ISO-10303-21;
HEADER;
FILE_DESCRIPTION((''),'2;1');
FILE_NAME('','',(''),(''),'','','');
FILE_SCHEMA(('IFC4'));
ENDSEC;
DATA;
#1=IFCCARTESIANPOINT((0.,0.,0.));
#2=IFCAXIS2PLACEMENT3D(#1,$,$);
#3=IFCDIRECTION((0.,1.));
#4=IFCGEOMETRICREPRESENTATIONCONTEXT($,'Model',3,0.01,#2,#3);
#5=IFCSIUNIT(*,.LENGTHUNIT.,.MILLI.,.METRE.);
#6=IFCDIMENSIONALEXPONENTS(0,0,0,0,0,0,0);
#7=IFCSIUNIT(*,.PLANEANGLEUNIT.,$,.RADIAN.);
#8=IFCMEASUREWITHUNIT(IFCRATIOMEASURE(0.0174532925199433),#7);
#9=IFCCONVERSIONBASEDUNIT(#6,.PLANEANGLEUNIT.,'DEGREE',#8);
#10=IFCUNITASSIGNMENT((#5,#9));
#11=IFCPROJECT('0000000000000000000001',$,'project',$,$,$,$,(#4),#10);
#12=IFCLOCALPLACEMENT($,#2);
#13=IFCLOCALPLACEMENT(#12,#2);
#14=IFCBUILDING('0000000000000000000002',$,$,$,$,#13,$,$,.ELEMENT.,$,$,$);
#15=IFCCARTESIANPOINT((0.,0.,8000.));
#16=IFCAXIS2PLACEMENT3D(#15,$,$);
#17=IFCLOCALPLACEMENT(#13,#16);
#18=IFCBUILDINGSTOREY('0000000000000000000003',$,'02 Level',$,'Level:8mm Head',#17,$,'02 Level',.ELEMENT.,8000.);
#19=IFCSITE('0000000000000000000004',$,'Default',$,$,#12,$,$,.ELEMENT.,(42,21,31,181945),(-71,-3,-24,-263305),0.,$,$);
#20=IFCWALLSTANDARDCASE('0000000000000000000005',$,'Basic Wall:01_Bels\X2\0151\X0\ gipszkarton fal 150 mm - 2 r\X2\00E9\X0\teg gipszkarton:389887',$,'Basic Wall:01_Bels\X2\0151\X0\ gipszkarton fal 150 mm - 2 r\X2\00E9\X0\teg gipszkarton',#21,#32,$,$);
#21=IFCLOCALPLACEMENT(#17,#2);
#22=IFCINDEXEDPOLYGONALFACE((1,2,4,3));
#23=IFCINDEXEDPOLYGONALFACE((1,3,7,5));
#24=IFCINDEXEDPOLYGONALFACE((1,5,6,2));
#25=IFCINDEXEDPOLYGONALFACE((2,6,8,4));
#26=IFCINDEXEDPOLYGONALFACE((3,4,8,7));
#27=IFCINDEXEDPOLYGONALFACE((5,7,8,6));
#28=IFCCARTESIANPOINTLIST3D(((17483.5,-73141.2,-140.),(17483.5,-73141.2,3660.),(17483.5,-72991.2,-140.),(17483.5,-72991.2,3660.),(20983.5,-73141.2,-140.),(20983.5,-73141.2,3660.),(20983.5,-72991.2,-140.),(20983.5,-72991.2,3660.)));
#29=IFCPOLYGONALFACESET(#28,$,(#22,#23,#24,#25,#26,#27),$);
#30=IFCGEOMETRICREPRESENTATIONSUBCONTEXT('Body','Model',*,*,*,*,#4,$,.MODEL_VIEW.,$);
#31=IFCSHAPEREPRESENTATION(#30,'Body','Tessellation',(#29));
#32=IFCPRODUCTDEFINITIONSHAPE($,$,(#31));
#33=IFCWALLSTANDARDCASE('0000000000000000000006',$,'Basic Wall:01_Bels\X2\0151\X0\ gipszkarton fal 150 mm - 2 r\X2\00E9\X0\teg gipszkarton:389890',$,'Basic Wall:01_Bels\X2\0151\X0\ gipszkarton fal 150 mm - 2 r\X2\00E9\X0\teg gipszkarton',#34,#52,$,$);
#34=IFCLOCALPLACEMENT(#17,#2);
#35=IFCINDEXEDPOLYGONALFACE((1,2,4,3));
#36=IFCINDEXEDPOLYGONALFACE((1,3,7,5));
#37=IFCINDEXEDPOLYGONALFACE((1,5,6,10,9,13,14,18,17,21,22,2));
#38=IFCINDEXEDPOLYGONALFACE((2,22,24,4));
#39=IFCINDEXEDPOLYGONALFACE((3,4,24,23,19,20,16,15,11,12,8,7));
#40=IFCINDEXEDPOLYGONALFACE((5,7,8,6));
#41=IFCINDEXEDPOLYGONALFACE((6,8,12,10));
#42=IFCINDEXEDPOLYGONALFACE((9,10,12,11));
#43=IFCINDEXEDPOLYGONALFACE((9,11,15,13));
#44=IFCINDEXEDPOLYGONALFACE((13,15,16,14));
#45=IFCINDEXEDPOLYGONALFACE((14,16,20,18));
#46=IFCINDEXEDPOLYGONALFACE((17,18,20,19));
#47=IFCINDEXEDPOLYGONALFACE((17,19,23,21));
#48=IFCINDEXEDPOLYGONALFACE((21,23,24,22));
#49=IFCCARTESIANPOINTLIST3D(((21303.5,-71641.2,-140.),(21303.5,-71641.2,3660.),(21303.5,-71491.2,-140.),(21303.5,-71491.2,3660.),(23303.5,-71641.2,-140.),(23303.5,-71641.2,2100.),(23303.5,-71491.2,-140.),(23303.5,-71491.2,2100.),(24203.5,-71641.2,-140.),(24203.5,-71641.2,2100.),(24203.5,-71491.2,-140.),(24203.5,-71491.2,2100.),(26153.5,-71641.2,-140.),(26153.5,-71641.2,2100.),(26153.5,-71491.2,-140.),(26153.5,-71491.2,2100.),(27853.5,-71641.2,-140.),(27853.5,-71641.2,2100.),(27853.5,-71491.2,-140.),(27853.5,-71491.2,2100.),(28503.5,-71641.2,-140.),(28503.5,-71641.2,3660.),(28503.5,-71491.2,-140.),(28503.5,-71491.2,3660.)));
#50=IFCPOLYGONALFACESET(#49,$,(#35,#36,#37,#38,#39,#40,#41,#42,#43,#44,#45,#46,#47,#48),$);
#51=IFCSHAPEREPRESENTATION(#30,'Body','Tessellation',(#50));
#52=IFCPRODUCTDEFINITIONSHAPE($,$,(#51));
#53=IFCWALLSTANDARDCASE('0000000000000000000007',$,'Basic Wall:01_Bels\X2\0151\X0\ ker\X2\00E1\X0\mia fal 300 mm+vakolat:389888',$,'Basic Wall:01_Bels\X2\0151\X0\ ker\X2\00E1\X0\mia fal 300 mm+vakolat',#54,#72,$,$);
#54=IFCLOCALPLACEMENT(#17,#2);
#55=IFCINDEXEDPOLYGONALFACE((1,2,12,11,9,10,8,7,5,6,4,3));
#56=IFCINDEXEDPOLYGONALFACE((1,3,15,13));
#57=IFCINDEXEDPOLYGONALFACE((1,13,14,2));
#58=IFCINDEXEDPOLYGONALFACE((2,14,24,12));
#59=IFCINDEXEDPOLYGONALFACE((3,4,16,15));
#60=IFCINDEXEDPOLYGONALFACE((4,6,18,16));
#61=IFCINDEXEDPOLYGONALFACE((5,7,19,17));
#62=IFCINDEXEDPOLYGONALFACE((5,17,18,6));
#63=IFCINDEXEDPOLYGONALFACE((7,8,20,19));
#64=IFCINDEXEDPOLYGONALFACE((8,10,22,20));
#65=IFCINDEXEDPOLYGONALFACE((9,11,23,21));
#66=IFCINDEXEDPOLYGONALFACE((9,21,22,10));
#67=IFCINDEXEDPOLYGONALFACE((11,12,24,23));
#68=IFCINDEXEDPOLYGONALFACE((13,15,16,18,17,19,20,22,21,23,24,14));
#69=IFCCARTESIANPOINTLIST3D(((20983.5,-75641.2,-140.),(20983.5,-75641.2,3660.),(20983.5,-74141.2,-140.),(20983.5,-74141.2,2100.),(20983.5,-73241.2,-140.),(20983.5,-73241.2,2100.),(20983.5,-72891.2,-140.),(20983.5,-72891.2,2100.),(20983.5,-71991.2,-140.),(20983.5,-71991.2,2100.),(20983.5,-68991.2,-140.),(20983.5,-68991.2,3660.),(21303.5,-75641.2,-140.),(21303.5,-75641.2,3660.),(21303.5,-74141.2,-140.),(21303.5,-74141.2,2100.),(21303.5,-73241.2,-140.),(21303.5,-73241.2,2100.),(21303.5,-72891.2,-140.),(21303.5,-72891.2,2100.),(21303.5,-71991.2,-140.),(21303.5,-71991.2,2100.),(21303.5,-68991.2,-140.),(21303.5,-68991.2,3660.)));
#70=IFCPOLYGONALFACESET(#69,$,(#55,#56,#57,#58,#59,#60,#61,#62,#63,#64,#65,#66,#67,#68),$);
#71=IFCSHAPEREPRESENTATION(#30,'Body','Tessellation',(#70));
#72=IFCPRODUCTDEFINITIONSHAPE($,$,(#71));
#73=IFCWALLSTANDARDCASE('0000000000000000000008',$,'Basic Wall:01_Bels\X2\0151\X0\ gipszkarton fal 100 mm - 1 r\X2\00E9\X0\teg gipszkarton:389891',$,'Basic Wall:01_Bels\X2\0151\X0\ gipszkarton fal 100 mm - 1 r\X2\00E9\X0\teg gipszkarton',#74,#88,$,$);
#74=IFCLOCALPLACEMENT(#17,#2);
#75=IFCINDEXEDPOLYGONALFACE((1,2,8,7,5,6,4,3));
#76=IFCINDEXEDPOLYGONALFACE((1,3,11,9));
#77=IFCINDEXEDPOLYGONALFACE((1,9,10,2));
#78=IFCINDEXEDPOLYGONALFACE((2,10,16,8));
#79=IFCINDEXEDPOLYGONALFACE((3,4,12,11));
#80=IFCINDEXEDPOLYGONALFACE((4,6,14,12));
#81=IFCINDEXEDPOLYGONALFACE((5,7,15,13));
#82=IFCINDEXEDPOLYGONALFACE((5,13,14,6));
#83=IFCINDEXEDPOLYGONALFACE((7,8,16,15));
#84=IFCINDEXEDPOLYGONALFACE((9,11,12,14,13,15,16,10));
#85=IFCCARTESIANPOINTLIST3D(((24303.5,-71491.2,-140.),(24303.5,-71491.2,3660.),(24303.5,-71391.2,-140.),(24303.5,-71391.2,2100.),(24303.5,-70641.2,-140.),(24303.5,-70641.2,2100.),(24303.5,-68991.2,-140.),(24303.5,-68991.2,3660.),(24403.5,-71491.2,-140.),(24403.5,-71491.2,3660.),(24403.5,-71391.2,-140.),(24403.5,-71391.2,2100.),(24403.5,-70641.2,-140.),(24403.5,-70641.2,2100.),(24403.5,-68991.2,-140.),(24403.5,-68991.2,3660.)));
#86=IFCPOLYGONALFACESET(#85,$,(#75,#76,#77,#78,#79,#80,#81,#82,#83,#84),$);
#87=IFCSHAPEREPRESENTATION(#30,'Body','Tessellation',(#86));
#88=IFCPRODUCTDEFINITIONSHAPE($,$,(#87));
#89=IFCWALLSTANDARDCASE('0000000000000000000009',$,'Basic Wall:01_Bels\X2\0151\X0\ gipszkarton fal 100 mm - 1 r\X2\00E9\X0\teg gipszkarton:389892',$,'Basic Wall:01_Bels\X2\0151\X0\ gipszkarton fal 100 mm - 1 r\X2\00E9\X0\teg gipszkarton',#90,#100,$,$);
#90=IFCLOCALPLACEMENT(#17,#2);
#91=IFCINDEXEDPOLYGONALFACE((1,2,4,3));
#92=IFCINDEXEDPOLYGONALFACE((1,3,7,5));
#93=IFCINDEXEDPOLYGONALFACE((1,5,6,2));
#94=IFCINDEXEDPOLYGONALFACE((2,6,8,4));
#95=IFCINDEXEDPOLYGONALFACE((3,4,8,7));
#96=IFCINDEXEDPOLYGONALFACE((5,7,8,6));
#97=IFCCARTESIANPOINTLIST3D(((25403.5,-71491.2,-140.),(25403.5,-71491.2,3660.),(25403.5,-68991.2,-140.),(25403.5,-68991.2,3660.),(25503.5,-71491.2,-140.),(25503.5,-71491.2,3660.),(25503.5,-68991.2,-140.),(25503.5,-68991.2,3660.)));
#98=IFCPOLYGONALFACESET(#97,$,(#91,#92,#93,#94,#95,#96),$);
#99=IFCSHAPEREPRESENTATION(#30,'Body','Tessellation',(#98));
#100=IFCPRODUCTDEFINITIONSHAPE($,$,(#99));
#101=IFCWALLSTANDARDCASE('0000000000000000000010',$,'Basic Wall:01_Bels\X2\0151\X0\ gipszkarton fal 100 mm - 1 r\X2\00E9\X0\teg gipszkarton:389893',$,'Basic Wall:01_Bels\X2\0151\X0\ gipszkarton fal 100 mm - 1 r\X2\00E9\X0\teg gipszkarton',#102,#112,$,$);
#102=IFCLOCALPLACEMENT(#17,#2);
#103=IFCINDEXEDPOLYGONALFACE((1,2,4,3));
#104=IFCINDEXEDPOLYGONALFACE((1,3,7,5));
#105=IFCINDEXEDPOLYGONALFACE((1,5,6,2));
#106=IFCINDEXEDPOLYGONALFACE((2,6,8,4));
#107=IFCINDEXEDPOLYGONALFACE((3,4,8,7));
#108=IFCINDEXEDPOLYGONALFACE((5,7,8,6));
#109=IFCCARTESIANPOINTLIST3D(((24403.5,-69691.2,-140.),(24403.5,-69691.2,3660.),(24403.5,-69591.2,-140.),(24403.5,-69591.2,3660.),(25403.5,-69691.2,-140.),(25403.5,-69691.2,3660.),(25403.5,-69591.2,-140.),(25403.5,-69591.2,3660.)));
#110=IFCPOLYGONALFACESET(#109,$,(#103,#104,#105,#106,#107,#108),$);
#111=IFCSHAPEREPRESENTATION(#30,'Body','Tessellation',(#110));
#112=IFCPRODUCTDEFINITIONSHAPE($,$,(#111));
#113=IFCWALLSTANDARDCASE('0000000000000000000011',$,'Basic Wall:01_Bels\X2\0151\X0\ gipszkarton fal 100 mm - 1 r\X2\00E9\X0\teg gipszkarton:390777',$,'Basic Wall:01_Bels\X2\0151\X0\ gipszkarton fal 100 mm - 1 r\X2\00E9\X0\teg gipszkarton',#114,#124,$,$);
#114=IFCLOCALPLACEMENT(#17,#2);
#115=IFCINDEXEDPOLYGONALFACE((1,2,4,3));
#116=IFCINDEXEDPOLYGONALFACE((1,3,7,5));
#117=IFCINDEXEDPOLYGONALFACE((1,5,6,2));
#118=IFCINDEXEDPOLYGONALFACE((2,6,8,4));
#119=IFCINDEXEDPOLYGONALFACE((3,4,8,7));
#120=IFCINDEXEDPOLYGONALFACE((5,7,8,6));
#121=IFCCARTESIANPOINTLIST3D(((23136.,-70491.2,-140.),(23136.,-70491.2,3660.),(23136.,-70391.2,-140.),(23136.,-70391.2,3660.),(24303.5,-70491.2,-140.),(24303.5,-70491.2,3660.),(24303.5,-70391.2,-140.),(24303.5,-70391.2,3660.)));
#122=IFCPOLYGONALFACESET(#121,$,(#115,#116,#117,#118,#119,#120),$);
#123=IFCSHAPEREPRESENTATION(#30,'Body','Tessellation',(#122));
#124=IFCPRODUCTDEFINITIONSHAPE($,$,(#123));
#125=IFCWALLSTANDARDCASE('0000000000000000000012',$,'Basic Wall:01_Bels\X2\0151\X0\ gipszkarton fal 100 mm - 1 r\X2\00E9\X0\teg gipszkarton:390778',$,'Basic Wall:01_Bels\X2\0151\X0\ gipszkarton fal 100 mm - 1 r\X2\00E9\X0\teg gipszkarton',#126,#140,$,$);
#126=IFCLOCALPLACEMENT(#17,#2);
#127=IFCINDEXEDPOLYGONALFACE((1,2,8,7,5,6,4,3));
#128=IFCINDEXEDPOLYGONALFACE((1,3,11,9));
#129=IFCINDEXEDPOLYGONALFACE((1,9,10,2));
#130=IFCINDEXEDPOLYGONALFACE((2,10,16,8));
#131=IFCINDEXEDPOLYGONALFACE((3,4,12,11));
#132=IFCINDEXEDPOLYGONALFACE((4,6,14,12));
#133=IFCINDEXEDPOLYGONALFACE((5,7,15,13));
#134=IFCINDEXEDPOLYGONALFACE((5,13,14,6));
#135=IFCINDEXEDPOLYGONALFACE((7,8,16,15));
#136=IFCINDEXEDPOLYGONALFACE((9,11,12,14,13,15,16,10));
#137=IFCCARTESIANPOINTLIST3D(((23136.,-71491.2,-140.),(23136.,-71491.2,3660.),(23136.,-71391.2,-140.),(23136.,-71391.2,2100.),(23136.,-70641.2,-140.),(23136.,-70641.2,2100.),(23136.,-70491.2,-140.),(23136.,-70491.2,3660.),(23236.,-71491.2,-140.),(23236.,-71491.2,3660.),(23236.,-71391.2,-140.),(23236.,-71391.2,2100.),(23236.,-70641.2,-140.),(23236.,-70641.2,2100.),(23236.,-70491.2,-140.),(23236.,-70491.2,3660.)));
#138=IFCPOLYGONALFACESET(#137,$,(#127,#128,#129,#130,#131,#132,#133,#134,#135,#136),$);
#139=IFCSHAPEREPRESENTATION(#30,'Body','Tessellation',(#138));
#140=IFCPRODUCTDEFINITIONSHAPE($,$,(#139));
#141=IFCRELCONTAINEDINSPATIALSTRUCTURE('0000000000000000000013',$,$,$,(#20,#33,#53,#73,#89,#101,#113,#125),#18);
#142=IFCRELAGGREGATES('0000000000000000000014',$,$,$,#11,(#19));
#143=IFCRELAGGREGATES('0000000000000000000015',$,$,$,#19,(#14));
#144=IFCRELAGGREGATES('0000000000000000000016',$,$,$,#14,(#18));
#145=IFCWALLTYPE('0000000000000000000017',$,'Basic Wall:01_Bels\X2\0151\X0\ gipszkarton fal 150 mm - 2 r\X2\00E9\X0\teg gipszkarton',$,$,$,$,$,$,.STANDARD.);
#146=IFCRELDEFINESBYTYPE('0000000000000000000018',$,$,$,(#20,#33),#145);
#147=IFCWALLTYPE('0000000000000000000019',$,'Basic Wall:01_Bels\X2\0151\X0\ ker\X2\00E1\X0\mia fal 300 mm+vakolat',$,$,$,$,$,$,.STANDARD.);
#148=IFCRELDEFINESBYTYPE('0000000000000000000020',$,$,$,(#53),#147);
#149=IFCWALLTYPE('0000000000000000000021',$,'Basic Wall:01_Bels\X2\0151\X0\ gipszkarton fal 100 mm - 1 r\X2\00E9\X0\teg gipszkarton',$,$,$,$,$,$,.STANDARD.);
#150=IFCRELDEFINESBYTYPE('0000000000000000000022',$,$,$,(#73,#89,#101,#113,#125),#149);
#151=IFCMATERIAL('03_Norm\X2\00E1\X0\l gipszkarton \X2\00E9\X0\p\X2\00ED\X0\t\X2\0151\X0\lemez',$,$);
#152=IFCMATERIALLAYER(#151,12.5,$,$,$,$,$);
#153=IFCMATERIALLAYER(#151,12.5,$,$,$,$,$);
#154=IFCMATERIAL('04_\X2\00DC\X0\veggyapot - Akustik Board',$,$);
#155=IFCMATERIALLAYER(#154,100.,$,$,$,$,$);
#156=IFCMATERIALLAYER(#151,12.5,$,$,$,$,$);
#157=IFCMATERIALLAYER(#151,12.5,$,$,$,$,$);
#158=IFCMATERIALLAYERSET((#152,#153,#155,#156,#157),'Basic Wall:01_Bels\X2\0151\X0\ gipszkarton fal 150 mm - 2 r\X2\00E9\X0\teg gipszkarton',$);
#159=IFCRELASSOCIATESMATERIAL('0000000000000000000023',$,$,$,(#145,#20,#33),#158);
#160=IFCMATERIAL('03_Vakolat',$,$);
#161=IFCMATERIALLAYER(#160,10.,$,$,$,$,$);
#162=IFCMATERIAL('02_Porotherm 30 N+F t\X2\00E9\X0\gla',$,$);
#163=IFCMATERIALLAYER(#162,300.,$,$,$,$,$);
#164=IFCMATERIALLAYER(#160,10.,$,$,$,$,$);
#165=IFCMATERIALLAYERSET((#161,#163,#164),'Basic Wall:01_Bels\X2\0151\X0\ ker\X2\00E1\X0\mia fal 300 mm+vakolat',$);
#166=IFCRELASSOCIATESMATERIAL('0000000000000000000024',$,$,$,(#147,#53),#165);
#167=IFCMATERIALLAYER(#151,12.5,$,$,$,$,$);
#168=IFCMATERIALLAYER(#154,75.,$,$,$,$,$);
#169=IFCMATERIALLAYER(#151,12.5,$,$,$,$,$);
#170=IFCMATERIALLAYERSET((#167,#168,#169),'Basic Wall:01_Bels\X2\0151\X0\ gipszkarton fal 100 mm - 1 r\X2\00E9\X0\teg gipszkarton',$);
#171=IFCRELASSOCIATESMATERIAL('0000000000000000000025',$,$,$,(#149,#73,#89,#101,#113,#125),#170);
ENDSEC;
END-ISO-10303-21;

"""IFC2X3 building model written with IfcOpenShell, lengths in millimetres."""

from ifc_helpers import new_model, entity, si_unit, converted_unit, direction, frame, frame_2d, origin, place, context, subcontext, project, spatial, rectangle, extrude, material, layer, layer_set, layer_usage, type_object, element, save


model = new_model("IFC2X3")

# Units and contexts
model_context = context("Model", 3, precision=0.01, world=origin(), true_north=direction((0.0, 1.0)))
body_context = subcontext(model_context, "Body", "Model", "MODEL_VIEW")
ifc_project = project(units=[si_unit("LENGTHUNIT", "METRE", prefix="MILLI"), converted_unit("PLANEANGLEUNIT", "DEGREE", entity("IfcRatioMeasure", 0.0174532925199433), si_unit("PLANEANGLEUNIT", "RADIAN"), dimensions=[0, 0, 0, 0, 0, 0, 0])], contexts=[model_context])

# Site, building, storey
site_placement = place(None, origin())
site = spatial("IfcSite", under=ifc_project, at=site_placement, Name="Default", CompositionType="ELEMENT", RefLatitude=(42, 21, 31, 181945), RefLongitude=(-71, -3, -24, -263305), RefElevation=0.0)
building_placement = place(site_placement, origin())
building = spatial("IfcBuilding", under=site, at=building_placement, CompositionType="ELEMENT")
storey_placement = place(building_placement, frame((0.0, 0.0, 8000.0)))
storey = spatial("IfcBuildingStorey", under=building, at=storey_placement, Name="02 Level", ObjectType="Level:8mm Head", LongName="02 Level", CompositionType="ELEMENT", Elevation=8000.0)

# Wall
ifc_material_1 = material(Name="03_Normál gipszkarton építőlemez")
ifc_layer_1 = layer(ifc_material_1, 12.5)
ifc_layer_2 = layer(ifc_material_1, 12.5)
ifc_material_2 = material(Name="04_Üveggyapot - Akustik Board")
ifc_layer_3 = layer(ifc_material_2, 100.0)
ifc_layer_4 = layer(ifc_material_1, 12.5)
ifc_layer_5 = layer(ifc_material_1, 12.5)
ifc_layer_set_1 = layer_set([ifc_layer_1, ifc_layer_2, ifc_layer_3, ifc_layer_4, ifc_layer_5], Name="Basic Wall:01_Belső gipszkarton fal 150 mm - 2 réteg gipszkarton")
ifc_layer_usage_1 = layer_usage(ifc_layer_set_1, "AXIS2", "NEGATIVE", 75.0)
wall_type_1 = type_object("IfcWallType", Name="Basic Wall:01_Belső gipszkarton fal 150 mm - 2 réteg gipszkarton", PredefinedType="STANDARD", material=ifc_layer_set_1)
wall_1_placement = place(storey_placement, frame((17483.5, -73066.2, -140.0)))
element("IfcWallStandardCase", 1, at=wall_1_placement, inside=storey, type_object=wall_type_1, material=ifc_layer_usage_1, Name="Basic Wall:01_Belső gipszkarton fal 150 mm - 2 réteg gipszkarton:389887", ObjectType="Basic Wall:01_Belső gipszkarton fal 150 mm - 2 réteg gipszkarton", context=body_context, shape_type="SweptSolid", body=[
    extrude(rectangle(XDim=3500.0, YDim=150.0, at=frame_2d((1750.0, 0.0), x_axis=(-1.0, 0.0))), origin(), (0.0, 0.0, 1.0), 3800.0),
])

# Walls, openings
ifc_layer_usage_2 = layer_usage(ifc_layer_set_1, "AXIS2", "NEGATIVE", 75.0)
wall_2_placement = place(storey_placement, frame((21303.5, -71566.2, -140.0)))
wall_2 = element("IfcWallStandardCase", 2, at=wall_2_placement, inside=storey, type_object=wall_type_1, material=ifc_layer_usage_2, Name="Basic Wall:01_Belső gipszkarton fal 150 mm - 2 réteg gipszkarton:389890", ObjectType="Basic Wall:01_Belső gipszkarton fal 150 mm - 2 réteg gipszkarton", context=body_context, shape_type="SweptSolid", body=[
    extrude(rectangle(XDim=7200.0, YDim=150.0, at=frame_2d((3600.0, 0.0), x_axis=(-1.0, 0.0))), origin(), (0.0, 0.0, 1.0), 3800.0),
])
opening_1_placement = place(wall_2_placement, frame((4850.0, -75.0, 0.0)))
element("IfcOpeningElement", 3, at=opening_1_placement, cuts=wall_2, ObjectType="Opening", context=body_context, shape_type="SweptSolid", body=[
    extrude(rectangle(XDim=2240.0, YDim=1700.0, at=frame_2d((0.0, 0.0), x_axis=(1.0, 0.0))), frame((850.0, 0.0, 1120.0), z_axis=(0.0, 1.0, 0.0), x_axis=(0.0, 0.0, -1.0)), (0.0, 0.0, 1.0), 150.0),
])
opening_2_placement = place(wall_2_placement, frame((2000.0, -1449.0, 0.0)))
element("IfcOpeningElement", 4, at=opening_2_placement, cuts=wall_2, ObjectType="Opening", context=body_context, shape_type="SweptSolid", body=[
    extrude(rectangle(XDim=2240.0, YDim=900.0, at=frame_2d((0.0, 0.0), x_axis=(0.0, 1.0))), frame((450.0, 0.0, 1120.0), z_axis=(0.0, 1.0, 0.0), x_axis=(-1.0, 0.0, 0.0)), (0.0, 0.0, 1.0), 3048.0),
])
ifc_material_3 = material(Name="03_Vakolat")
ifc_layer_6 = layer(ifc_material_3, 10.0)
ifc_material_4 = material(Name="02_Porotherm 30 N+F tégla")
ifc_layer_7 = layer(ifc_material_4, 300.0)
ifc_layer_8 = layer(ifc_material_3, 10.0)
ifc_layer_set_2 = layer_set([ifc_layer_6, ifc_layer_7, ifc_layer_8], Name="Basic Wall:01_Belső kerámia fal 300 mm+vakolat")
ifc_layer_usage_3 = layer_usage(ifc_layer_set_2, "AXIS2", "NEGATIVE", 160.0)
wall_type_2 = type_object("IfcWallType", Name="Basic Wall:01_Belső kerámia fal 300 mm+vakolat", PredefinedType="STANDARD", material=ifc_layer_set_2)
wall_3_placement = place(storey_placement, frame((21143.5, -68991.2, -140.0), z_axis=(0.0, 0.0, 1.0), x_axis=(0.0, -1.0, 0.0)))
wall_3 = element("IfcWallStandardCase", 5, at=wall_3_placement, inside=storey, type_object=wall_type_2, material=ifc_layer_usage_3, Name="Basic Wall:01_Belső kerámia fal 300 mm+vakolat:389888", ObjectType="Basic Wall:01_Belső kerámia fal 300 mm+vakolat", context=body_context, shape_type="SweptSolid", body=[
    extrude(rectangle(XDim=6650.0, YDim=320.0, at=frame_2d((3325.0, 0.0), x_axis=(-1.0, 0.0))), origin(), (0.0, 0.0, 1.0), 3800.0),
])
opening_3_placement = place(wall_3_placement, frame((3900.0, -1364.0, 0.0), z_axis=(0.0, 0.0, 1.0), x_axis=(0.0, 1.0, 0.0)))
element("IfcOpeningElement", 6, at=opening_3_placement, cuts=wall_3, ObjectType="Opening", context=body_context, shape_type="SweptSolid", body=[
    extrude(rectangle(XDim=2240.0, YDim=900.0, at=frame_2d((0.0, 0.0), x_axis=(1.0, 0.0))), frame((0.0, 450.0, 1120.0), z_axis=(1.0, 0.0, 0.0), x_axis=(0.0, 0.0, 1.0)), (0.0, 0.0, 1.0), 3048.0),
])
opening_4_placement = place(wall_3_placement, frame((5150.0, -1364.0, 0.0), z_axis=(0.0, 0.0, 1.0), x_axis=(0.0, 1.0, 0.0)))
element("IfcOpeningElement", 7, at=opening_4_placement, cuts=wall_3, ObjectType="Opening", context=body_context, shape_type="SweptSolid", body=[
    extrude(rectangle(XDim=2240.0, YDim=900.0, at=frame_2d((0.0, 0.0), x_axis=(0.0, 1.0))), frame((0.0, 450.0, 1120.0), z_axis=(1.0, 0.0, 0.0), x_axis=(0.0, 1.0, 0.0)), (0.0, 0.0, 1.0), 3048.0),
])

# Wall, opening
ifc_layer_9 = layer(ifc_material_1, 12.5)
ifc_layer_10 = layer(ifc_material_2, 75.0)
ifc_layer_11 = layer(ifc_material_1, 12.5)
ifc_layer_set_3 = layer_set([ifc_layer_9, ifc_layer_10, ifc_layer_11], Name="Basic Wall:01_Belső gipszkarton fal 100 mm - 1 réteg gipszkarton")
ifc_layer_usage_4 = layer_usage(ifc_layer_set_3, "AXIS2", "NEGATIVE", 50.0)
wall_type_3 = type_object("IfcWallType", Name="Basic Wall:01_Belső gipszkarton fal 100 mm - 1 réteg gipszkarton", PredefinedType="STANDARD", material=ifc_layer_set_3)
wall_4_placement = place(storey_placement, frame((24353.5, -71491.2, -140.0), z_axis=(0.0, 0.0, 1.0), x_axis=(0.0, 1.0, 0.0)))
wall_4 = element("IfcWallStandardCase", 8, at=wall_4_placement, inside=storey, type_object=wall_type_3, material=ifc_layer_usage_4, Name="Basic Wall:01_Belső gipszkarton fal 100 mm - 1 réteg gipszkarton:389891", ObjectType="Basic Wall:01_Belső gipszkarton fal 100 mm - 1 réteg gipszkarton", context=body_context, shape_type="SweptSolid", body=[
    extrude(rectangle(XDim=2500.0, YDim=100.0, at=frame_2d((1250.0, 0.0), x_axis=(-1.0, 0.0))), origin(), (0.0, 0.0, 1.0), 3800.0),
])
opening_5_placement = place(wall_4_placement, frame((100.0, 1574.0, 0.0), z_axis=(0.0, 0.0, 1.0), x_axis=(0.0, -1.0, 0.0)))
element("IfcOpeningElement", 9, at=opening_5_placement, cuts=wall_4, ObjectType="Opening", context=body_context, shape_type="SweptSolid", body=[
    extrude(rectangle(XDim=2240.0, YDim=750.0, at=frame_2d((0.0, 0.0), x_axis=(0.0, 1.0))), frame((3048.0, 375.0, 1120.0), z_axis=(-1.0, 0.0, 0.0), x_axis=(0.0, -1.0, 0.0)), (0.0, 0.0, 1.0), 3048.0),
])

# Walls
ifc_layer_usage_5 = layer_usage(ifc_layer_set_3, "AXIS2", "NEGATIVE", 50.0)
wall_5_placement = place(storey_placement, frame((25453.5, -71491.2, -140.0), z_axis=(0.0, 0.0, 1.0), x_axis=(0.0, 1.0, 0.0)))
element("IfcWallStandardCase", 10, at=wall_5_placement, inside=storey, type_object=wall_type_3, material=ifc_layer_usage_5, Name="Basic Wall:01_Belső gipszkarton fal 100 mm - 1 réteg gipszkarton:389892", ObjectType="Basic Wall:01_Belső gipszkarton fal 100 mm - 1 réteg gipszkarton", context=body_context, shape_type="SweptSolid", body=[
    extrude(rectangle(XDim=2500.0, YDim=100.0, at=frame_2d((1250.0, 0.0), x_axis=(-1.0, 0.0))), origin(), (0.0, 0.0, 1.0), 3800.0),
])
ifc_layer_usage_6 = layer_usage(ifc_layer_set_3, "AXIS2", "NEGATIVE", 50.0)
wall_6_placement = place(storey_placement, frame((24403.5, -69641.2, -140.0)))
element("IfcWallStandardCase", 11, at=wall_6_placement, inside=storey, type_object=wall_type_3, material=ifc_layer_usage_6, Name="Basic Wall:01_Belső gipszkarton fal 100 mm - 1 réteg gipszkarton:389893", ObjectType="Basic Wall:01_Belső gipszkarton fal 100 mm - 1 réteg gipszkarton", context=body_context, shape_type="SweptSolid", body=[
    extrude(rectangle(XDim=1000.0, YDim=100.0, at=frame_2d((500.0, 0.0), x_axis=(-1.0, 0.0))), origin(), (0.0, 0.0, 1.0), 3800.0),
])
ifc_layer_usage_7 = layer_usage(ifc_layer_set_3, "AXIS2", "NEGATIVE", 50.0)
wall_7_placement = place(storey_placement, frame((24303.5, -70441.2, -140.0), z_axis=(0.0, 0.0, 1.0), x_axis=(-1.0, 0.0, 0.0)))
element("IfcWallStandardCase", 12, at=wall_7_placement, inside=storey, type_object=wall_type_3, material=ifc_layer_usage_7, Name="Basic Wall:01_Belső gipszkarton fal 100 mm - 1 réteg gipszkarton:390777", ObjectType="Basic Wall:01_Belső gipszkarton fal 100 mm - 1 réteg gipszkarton", context=body_context, shape_type="SweptSolid", body=[
    extrude(rectangle(XDim=1167.5, YDim=100.0, at=frame_2d((583.7, 0.0), x_axis=(-1.0, 0.0))), origin(), (0.0, 0.0, 1.0), 3800.0),
])

# Wall, opening
ifc_layer_usage_8 = layer_usage(ifc_layer_set_3, "AXIS2", "NEGATIVE", 50.0)
wall_8_placement = place(storey_placement, frame((23186.0, -70491.2, -140.0), z_axis=(0.0, 0.0, 1.0), x_axis=(0.0, -1.0, 0.0)))
wall_8 = element("IfcWallStandardCase", 13, at=wall_8_placement, inside=storey, type_object=wall_type_3, material=ifc_layer_usage_8, Name="Basic Wall:01_Belső gipszkarton fal 100 mm - 1 réteg gipszkarton:390778", ObjectType="Basic Wall:01_Belső gipszkarton fal 100 mm - 1 réteg gipszkarton", context=body_context, shape_type="SweptSolid", body=[
    extrude(rectangle(XDim=1000.0, YDim=100.0, at=frame_2d((500.0, 0.0), x_axis=(-1.0, 0.0))), origin(), (0.0, 0.0, 1.0), 3800.0),
])
opening_6_placement = place(wall_8_placement, frame((900.0, -1474.0, 0.0), z_axis=(0.0, 0.0, 1.0), x_axis=(0.0, 1.0, 0.0)))
element("IfcOpeningElement", 14, at=opening_6_placement, cuts=wall_8, ObjectType="Opening", context=body_context, shape_type="SweptSolid", body=[
    extrude(rectangle(XDim=2240.0, YDim=750.0, at=frame_2d((0.0, 0.0), x_axis=(1.0, 0.0))), frame((0.0, 375.0, 1120.0), z_axis=(1.0, 0.0, 0.0), x_axis=(0.0, 0.0, 1.0)), (0.0, 0.0, 1.0), 3048.0),
])

save(model, "model.ifc")
